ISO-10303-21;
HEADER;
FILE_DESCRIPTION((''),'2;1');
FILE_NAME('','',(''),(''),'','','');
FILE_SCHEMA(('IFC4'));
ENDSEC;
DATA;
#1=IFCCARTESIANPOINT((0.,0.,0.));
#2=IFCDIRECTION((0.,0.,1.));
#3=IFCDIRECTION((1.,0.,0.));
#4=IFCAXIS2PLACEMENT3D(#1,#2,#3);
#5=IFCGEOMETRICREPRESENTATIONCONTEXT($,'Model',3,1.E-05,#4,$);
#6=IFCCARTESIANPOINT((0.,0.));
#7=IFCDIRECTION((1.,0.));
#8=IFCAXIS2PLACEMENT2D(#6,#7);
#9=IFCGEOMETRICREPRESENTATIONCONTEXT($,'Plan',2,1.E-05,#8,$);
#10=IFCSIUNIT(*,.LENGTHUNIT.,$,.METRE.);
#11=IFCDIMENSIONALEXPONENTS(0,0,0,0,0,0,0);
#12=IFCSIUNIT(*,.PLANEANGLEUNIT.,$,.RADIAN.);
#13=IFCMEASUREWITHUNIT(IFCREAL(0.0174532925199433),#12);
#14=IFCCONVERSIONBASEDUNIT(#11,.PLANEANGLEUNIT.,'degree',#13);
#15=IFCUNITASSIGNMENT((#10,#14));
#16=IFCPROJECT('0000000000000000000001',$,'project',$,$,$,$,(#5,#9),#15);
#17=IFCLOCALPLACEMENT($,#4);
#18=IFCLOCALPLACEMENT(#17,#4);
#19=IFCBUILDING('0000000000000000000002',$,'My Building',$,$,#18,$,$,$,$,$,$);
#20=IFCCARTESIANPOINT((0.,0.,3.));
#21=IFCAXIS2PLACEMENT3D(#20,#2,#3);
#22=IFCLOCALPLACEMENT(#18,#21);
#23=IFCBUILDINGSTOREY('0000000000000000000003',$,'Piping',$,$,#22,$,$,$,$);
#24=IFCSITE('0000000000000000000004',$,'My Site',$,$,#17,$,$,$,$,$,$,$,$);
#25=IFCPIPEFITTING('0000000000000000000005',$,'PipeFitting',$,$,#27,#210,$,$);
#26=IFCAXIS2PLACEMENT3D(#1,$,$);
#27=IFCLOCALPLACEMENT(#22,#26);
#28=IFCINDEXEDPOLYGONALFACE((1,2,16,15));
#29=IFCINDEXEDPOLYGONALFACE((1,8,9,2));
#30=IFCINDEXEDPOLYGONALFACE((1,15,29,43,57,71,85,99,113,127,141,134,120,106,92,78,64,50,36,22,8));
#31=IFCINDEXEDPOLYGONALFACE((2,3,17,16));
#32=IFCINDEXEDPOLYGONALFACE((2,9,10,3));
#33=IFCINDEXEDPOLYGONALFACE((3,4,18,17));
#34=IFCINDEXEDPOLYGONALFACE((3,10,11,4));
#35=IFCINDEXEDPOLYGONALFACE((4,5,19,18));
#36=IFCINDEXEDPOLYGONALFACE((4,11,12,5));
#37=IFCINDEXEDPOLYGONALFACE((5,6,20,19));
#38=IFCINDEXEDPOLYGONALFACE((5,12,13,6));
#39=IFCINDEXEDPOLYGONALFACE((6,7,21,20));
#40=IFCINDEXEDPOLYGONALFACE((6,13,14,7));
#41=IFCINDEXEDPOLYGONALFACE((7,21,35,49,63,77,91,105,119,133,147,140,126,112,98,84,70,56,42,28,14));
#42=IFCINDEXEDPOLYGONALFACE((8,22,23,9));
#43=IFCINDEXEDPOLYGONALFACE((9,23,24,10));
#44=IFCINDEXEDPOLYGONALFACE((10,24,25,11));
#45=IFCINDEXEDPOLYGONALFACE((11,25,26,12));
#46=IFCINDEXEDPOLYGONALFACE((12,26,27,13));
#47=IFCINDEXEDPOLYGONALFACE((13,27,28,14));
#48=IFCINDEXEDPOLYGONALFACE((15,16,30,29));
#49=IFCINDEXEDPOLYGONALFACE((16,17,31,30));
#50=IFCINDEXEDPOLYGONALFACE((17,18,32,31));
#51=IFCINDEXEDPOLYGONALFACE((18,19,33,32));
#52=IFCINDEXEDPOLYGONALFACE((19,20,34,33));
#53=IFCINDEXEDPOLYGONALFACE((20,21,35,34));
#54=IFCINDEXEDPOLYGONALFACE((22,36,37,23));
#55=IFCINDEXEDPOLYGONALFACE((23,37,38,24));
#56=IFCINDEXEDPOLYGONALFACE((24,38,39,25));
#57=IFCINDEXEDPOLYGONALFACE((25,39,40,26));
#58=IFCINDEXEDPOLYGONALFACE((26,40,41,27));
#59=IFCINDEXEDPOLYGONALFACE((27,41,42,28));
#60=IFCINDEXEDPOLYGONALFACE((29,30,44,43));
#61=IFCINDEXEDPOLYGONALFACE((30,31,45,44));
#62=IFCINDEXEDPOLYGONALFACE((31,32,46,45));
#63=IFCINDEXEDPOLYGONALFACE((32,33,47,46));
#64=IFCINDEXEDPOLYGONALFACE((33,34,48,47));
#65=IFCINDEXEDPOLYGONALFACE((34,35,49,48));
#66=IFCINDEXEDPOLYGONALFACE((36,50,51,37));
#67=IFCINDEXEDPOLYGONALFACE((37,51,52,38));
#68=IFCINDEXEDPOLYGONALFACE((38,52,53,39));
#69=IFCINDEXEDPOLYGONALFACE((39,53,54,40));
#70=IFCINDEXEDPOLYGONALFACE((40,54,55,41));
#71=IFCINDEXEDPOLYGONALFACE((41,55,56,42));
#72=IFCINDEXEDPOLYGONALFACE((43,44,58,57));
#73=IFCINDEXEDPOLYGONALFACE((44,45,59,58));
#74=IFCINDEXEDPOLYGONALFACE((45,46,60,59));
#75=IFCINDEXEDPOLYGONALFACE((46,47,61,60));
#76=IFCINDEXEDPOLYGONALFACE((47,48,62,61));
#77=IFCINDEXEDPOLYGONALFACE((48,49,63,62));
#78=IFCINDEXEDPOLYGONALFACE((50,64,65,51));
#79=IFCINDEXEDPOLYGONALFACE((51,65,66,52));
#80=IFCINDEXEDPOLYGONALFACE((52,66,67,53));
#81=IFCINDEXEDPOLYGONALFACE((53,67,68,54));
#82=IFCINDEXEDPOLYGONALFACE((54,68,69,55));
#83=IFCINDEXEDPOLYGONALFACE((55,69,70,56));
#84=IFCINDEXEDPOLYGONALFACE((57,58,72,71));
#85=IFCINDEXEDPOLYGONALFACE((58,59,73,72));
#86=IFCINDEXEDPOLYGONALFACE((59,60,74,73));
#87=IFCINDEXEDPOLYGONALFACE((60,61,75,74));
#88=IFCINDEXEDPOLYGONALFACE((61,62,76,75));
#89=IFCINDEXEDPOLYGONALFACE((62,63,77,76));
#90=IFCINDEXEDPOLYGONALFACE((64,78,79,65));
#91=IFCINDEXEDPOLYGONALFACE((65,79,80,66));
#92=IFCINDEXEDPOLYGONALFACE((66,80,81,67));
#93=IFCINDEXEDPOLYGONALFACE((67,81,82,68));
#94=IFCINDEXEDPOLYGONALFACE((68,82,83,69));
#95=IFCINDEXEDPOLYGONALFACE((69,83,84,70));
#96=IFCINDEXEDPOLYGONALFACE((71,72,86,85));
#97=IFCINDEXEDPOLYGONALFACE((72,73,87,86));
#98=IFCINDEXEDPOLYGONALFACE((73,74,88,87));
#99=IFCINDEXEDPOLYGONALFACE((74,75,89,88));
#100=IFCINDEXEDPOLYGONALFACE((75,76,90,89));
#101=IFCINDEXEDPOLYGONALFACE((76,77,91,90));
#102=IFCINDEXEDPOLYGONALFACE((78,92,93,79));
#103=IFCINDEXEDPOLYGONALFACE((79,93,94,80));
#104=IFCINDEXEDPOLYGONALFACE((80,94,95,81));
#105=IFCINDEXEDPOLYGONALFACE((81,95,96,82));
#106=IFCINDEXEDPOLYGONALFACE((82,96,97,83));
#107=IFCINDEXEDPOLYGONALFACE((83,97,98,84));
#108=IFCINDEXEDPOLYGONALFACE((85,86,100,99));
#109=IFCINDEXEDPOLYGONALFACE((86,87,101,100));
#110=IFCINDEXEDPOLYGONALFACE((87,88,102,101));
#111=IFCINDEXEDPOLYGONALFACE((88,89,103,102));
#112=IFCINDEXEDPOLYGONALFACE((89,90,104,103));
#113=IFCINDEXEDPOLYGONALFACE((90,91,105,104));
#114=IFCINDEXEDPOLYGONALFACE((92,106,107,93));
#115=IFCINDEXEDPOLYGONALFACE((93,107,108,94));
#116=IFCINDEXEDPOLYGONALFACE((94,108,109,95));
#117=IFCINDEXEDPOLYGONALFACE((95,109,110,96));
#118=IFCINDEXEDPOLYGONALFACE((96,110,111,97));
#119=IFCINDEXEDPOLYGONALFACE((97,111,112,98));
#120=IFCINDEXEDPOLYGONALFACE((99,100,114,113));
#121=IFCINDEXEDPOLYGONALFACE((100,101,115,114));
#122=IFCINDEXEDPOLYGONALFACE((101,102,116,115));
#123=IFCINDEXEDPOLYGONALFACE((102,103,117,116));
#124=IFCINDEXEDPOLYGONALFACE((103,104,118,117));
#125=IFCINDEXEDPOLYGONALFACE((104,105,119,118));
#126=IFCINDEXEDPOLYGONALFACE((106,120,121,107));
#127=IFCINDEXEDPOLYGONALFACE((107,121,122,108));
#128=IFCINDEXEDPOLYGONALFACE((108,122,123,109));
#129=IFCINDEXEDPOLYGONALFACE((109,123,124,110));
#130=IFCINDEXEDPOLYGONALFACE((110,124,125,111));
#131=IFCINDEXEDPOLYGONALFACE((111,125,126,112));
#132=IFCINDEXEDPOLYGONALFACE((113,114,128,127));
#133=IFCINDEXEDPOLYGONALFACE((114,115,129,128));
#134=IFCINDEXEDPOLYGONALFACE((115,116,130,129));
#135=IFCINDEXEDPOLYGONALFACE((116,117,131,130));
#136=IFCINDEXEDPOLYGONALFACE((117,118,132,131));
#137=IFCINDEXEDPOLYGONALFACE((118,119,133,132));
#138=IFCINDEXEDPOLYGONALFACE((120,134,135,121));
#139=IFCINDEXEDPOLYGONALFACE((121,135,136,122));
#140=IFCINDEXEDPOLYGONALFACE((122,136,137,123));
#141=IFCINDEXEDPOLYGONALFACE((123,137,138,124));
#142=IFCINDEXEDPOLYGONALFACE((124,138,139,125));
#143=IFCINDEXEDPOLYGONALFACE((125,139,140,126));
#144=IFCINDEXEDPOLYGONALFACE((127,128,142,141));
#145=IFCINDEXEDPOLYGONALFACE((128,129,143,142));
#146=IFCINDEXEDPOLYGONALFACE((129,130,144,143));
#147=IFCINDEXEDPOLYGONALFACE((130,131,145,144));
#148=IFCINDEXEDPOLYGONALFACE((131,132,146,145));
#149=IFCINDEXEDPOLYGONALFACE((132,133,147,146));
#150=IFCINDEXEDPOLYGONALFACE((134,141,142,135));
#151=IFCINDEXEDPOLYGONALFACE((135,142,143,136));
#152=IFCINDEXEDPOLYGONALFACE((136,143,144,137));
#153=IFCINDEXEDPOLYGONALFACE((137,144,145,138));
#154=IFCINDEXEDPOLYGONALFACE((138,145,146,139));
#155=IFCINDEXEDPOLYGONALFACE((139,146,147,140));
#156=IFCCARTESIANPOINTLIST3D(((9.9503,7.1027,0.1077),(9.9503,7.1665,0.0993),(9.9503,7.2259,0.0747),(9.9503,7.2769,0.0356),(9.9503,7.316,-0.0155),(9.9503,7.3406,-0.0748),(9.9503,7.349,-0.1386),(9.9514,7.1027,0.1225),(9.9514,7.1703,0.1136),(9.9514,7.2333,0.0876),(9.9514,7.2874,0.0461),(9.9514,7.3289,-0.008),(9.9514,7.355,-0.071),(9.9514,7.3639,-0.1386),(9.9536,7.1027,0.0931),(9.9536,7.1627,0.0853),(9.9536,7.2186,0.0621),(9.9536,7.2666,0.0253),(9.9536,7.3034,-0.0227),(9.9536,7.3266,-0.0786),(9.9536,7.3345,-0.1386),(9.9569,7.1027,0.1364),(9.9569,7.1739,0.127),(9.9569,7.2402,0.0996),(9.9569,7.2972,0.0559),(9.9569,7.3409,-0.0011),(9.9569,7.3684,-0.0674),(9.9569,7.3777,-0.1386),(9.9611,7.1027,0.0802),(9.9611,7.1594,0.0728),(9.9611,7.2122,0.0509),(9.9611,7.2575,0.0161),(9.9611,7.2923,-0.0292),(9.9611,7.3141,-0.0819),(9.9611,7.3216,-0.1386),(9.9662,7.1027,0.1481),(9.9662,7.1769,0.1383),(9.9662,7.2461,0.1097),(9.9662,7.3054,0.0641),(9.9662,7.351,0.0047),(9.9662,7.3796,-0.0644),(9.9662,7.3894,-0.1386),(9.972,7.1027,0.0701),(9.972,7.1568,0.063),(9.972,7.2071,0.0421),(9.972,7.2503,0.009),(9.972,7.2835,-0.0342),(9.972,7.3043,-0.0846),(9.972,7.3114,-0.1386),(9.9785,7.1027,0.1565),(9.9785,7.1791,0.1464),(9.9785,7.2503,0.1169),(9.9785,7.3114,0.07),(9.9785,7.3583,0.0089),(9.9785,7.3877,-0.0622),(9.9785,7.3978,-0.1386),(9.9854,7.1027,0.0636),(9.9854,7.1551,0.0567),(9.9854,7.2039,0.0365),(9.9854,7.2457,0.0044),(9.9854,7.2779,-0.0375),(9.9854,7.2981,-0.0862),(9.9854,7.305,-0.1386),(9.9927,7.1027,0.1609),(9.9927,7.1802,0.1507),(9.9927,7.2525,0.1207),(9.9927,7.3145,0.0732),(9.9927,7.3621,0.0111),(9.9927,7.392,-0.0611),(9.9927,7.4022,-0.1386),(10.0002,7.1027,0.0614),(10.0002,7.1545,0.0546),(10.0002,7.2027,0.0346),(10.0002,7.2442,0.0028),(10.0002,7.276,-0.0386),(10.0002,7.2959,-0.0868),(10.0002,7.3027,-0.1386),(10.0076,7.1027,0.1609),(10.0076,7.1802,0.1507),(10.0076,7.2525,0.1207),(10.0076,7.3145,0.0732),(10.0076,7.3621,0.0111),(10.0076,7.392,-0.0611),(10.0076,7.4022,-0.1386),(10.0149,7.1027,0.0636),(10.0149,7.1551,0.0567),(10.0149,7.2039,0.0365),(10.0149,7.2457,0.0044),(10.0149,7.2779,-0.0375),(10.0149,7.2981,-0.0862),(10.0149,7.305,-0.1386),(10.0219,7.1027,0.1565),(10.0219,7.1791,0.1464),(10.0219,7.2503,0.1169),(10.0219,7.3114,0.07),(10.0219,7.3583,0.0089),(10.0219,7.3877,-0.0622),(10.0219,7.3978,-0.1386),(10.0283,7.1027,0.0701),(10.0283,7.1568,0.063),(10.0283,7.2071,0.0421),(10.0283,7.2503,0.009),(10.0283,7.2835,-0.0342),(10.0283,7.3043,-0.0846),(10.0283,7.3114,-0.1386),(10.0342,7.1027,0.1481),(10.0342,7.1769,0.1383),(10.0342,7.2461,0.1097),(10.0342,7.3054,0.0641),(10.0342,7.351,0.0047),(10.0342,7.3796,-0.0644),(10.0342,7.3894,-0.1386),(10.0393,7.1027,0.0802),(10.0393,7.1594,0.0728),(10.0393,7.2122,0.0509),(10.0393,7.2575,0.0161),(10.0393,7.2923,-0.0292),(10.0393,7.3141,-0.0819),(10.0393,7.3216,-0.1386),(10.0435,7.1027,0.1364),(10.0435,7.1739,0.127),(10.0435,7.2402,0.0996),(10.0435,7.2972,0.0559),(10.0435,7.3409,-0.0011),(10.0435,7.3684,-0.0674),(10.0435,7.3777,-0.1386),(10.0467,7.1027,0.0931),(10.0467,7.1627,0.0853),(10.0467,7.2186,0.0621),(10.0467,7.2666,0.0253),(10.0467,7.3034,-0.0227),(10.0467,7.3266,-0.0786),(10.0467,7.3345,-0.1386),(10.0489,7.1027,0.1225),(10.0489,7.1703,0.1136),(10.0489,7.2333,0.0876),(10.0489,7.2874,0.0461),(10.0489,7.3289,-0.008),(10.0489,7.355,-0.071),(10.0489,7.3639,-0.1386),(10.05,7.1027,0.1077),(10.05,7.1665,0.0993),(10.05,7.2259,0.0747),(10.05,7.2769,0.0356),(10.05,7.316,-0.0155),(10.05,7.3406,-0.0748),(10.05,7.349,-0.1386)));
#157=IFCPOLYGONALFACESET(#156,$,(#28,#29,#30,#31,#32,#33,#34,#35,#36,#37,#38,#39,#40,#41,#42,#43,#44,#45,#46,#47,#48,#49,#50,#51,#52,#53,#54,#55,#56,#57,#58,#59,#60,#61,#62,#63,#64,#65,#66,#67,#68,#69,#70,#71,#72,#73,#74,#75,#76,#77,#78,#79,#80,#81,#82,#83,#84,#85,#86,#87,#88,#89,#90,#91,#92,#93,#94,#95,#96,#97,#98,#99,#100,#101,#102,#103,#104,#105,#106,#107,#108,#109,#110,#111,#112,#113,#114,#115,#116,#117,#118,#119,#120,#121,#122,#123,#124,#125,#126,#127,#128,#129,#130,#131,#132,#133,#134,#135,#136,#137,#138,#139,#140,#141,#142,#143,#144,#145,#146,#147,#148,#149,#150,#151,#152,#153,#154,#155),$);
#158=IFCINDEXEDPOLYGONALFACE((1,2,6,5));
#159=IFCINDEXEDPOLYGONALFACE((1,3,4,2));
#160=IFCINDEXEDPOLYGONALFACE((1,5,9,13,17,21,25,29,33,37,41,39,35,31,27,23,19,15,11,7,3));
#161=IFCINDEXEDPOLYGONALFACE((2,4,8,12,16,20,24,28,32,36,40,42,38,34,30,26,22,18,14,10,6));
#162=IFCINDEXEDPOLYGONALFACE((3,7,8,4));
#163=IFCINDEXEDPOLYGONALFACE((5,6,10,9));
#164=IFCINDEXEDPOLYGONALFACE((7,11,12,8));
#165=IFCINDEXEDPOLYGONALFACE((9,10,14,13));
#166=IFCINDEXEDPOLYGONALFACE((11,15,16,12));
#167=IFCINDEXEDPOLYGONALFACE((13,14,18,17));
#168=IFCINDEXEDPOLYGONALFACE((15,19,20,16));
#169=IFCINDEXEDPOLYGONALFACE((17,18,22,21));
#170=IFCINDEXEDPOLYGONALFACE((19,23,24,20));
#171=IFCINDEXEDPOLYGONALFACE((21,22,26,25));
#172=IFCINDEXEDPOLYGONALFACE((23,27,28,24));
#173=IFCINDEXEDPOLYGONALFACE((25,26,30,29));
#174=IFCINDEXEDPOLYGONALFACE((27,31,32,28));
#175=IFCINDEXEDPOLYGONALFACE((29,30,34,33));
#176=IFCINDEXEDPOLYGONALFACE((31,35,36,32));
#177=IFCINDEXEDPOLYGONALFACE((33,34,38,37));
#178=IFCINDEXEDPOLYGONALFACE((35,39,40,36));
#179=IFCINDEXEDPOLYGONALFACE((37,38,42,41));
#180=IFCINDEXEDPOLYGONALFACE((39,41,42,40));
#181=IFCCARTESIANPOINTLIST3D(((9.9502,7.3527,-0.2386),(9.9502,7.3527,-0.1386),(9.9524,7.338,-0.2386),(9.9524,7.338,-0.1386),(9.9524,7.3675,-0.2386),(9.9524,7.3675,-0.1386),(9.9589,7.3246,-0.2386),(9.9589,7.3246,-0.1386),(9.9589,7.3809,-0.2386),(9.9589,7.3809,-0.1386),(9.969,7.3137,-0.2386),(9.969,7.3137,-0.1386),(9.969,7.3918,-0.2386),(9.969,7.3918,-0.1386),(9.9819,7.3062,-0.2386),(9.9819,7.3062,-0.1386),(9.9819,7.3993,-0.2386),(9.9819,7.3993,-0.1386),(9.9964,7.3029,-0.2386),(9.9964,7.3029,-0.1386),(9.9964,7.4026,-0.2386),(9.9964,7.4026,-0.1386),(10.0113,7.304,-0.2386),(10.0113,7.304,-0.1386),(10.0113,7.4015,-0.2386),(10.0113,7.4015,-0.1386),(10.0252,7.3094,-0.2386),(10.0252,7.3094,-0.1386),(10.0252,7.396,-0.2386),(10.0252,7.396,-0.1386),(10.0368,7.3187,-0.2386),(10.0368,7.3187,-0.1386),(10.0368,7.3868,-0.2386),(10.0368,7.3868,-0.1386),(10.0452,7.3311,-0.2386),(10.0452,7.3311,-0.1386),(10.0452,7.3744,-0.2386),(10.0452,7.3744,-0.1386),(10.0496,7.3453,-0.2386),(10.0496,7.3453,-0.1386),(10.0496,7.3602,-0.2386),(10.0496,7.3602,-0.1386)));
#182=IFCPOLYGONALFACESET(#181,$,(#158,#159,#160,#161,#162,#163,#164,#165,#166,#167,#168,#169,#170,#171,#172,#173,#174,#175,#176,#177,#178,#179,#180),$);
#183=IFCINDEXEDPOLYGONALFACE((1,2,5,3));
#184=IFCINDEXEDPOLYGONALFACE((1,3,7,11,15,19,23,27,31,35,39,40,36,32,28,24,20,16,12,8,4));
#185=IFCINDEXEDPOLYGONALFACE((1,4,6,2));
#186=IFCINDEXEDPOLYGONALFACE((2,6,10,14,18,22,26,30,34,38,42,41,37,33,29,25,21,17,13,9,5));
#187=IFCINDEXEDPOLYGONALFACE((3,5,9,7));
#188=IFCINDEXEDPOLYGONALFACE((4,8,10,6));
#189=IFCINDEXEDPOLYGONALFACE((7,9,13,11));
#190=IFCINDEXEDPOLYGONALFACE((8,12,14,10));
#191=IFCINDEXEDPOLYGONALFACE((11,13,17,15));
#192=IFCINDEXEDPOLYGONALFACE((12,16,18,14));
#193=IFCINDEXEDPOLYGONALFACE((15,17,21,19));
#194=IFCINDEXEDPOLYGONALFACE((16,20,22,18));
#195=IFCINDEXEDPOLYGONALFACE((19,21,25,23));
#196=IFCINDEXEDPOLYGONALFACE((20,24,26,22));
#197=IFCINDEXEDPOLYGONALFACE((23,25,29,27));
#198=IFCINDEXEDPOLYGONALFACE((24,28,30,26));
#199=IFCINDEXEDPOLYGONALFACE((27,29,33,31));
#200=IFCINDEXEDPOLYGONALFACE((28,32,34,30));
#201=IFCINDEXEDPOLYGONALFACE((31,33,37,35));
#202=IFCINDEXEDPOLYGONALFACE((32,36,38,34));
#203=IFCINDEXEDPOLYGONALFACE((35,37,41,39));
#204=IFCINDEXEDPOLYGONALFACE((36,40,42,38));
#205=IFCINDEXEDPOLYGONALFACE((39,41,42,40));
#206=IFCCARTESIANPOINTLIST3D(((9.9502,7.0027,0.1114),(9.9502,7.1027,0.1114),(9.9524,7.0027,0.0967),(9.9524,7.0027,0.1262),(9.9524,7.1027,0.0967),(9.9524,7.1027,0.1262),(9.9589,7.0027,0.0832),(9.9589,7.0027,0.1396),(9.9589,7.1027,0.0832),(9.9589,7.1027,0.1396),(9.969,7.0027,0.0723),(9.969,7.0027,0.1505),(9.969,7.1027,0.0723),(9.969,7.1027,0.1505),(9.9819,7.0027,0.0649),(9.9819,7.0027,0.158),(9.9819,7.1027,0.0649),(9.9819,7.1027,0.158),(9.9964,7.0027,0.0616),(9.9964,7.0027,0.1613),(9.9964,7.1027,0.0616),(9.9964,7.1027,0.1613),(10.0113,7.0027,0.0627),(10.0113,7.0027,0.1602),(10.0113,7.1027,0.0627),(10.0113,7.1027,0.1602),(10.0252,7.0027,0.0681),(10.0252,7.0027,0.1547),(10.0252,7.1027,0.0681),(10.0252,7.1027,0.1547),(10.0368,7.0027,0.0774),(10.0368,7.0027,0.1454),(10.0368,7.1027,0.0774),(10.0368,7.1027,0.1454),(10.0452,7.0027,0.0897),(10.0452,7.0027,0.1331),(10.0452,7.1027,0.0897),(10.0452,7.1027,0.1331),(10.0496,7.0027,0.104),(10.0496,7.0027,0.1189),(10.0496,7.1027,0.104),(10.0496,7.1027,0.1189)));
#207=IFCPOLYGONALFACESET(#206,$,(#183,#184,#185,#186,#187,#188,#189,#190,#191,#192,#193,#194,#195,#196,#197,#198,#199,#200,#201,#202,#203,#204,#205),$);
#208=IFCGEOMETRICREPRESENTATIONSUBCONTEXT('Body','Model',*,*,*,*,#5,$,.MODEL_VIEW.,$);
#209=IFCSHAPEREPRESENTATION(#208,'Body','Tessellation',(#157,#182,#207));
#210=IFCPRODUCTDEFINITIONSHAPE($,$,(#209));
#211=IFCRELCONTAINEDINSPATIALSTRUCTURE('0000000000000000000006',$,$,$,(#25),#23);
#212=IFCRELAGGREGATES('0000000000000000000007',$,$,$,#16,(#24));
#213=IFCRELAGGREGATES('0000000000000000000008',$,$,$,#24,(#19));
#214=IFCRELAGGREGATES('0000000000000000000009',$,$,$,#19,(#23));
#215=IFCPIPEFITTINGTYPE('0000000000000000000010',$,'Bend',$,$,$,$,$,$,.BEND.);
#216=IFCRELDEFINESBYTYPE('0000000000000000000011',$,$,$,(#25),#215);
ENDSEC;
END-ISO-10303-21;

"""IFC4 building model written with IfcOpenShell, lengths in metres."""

from ifc_helpers import new_model, entity, si_unit, converted_unit, frame, origin_with_axes, origin_2d_with_axis, place, context, subcontext, project, spatial, circle, extrude, source, transform, mapped, type_object, type_shapes, element, save


model = new_model("IFC4")

# Units and contexts
model_context = context("Model", 3, precision=1e-05, world=origin_with_axes())
plan_context = context("Plan", 2, precision=1e-05, world=origin_2d_with_axis())
body_context = subcontext(model_context, "Body", "Model", "MODEL_VIEW")
ifc_project = project(units=[si_unit("LENGTHUNIT", "METRE"), converted_unit("PLANEANGLEUNIT", "degree", entity("IfcReal", 0.0174532925199433), si_unit("PLANEANGLEUNIT", "RADIAN"), dimensions=[0, 0, 0, 0, 0, 0, 0])], contexts=[model_context, plan_context])

# Site, building, storey
site_placement = place(None, origin_with_axes())
site = spatial("IfcSite", under=ifc_project, at=site_placement, Name="My Site")
building_placement = place(site_placement, origin_with_axes())
building = spatial("IfcBuilding", under=site, at=building_placement, Name="My Building")
storey_placement = place(building_placement, frame((0.0, 0.0, 3.0), z_axis=(0.0, 0.0, 1.0), x_axis=(1.0, 0.0, 0.0)))
storey = spatial("IfcBuildingStorey", under=building, at=storey_placement, Name="Piping")

# Pipe fitting
pipe_fitting_type_1 = type_object("IfcPipeFittingType", Name="Bend", PredefinedType="BEND")
shared_shape = source(origin_with_axes(), body_context, "Body", "SolidModel", [
    entity("IfcSweptDiskSolid", entity("IfcIndexedPolyCurve", entity("IfcCartesianPointList3D", [[0.0, 0.0, -0.1], [0.0, -0.0732, -0.2768], [0.0, -0.25, -0.35]]), [entity("IfcArcIndex", [1, 2, 3])]), 0.05),
    extrude(circle(Radius=0.05), origin_with_axes(), (0.0, 0.0, -1.0), 0.1),
    extrude(circle(Radius=0.05), frame((0.0, -0.25, -0.35), z_axis=(0.0, -1.0, 0.0), x_axis=(1.0, 0.0, 0.0)), (0.0, 0.0, 1.0), 0.1),
])
type_shapes(pipe_fitting_type_1, [shared_shape])
for number, where, z_axis, x_axis, name in (
    (1, (10.0002, 7.3527, -0.2386), (0.0, 0.0, -1.0), (-1.0, 0.0, 0.0), "PipeFitting"),
):
    element("IfcPipeFitting", number, at=place(storey_placement, frame(where, z_axis=z_axis, x_axis=x_axis)), inside=storey, type_object=pipe_fitting_type_1, Name=name, context=body_context, shape_type="MappedRepresentation", body=[
        mapped(shared_shape, transform((0.0, 0.0, 0.0), x_axis=(1.0, 0.0, 0.0), y_axis=(0.0, 1.0, 0.0), z_axis=(0.0, 0.0, 1.0), scale=1.0)),
    ])

save(model, "model.ifc")
